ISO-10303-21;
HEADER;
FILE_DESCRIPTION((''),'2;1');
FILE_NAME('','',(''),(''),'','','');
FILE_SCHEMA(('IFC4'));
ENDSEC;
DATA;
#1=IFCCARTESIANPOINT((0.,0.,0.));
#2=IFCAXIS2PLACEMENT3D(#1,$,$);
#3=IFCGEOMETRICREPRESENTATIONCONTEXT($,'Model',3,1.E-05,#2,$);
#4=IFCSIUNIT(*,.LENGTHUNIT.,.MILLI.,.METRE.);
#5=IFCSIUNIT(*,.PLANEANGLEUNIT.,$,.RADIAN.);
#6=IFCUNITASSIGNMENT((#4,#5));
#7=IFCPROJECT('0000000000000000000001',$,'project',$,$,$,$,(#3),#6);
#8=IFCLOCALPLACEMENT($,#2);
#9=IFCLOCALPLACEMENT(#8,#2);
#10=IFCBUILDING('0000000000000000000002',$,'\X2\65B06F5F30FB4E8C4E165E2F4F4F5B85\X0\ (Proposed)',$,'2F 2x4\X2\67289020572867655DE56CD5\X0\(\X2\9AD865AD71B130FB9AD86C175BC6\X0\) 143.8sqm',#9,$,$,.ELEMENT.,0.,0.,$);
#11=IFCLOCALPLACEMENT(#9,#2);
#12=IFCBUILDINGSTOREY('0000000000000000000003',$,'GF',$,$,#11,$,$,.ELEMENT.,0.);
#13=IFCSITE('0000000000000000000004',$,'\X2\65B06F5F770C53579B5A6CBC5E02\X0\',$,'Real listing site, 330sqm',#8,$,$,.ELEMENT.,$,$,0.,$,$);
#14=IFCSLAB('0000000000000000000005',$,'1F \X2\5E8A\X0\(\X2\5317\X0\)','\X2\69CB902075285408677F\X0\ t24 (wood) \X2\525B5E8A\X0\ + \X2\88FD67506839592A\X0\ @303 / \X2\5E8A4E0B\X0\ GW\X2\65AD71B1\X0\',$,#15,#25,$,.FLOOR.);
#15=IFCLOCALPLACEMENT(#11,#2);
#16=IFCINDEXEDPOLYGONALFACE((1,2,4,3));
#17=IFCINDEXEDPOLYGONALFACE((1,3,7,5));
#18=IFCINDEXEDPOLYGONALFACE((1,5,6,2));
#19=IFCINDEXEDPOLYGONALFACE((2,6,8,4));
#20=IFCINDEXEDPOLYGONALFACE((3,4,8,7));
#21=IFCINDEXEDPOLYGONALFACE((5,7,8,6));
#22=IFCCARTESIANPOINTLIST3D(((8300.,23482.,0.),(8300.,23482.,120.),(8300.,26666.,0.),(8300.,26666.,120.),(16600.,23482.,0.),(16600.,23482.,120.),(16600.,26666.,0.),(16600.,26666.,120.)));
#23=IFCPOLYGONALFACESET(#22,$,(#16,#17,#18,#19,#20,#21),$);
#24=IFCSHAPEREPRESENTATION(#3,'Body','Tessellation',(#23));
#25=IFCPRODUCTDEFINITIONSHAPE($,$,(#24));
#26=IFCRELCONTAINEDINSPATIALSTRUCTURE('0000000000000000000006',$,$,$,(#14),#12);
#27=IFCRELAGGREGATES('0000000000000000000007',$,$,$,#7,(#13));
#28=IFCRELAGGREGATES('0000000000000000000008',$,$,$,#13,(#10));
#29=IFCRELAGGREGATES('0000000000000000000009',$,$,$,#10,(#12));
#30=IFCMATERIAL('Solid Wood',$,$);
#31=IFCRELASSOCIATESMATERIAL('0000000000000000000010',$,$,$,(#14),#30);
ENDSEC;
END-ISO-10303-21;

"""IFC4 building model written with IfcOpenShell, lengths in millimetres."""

from ifc_helpers import new_model, si_unit, frame, frame_2d, origin, place, context, project, spatial, rectangle, extrude, material, element, save


model = new_model("IFC4")

# Units and contexts
model_context = context("Model", 3, precision=1e-05, world=origin())
ifc_project = project(units=[si_unit("LENGTHUNIT", "METRE", prefix="MILLI"), si_unit("PLANEANGLEUNIT", "RADIAN")], contexts=[model_context])

# Site, building, storey
site_placement = place(None, origin())
site = spatial("IfcSite", under=ifc_project, at=site_placement, Name="新潟県南魚沼市", ObjectType="Real listing site, 330sqm", CompositionType="ELEMENT", RefElevation=0.0)
building_placement = place(site_placement, origin())
building = spatial("IfcBuilding", under=site, at=building_placement, Name="新潟・二世帯住宅 (Proposed)", ObjectType="2F 2x4木造在来工法(高断熱・高気密) 143.8sqm", CompositionType="ELEMENT", ElevationOfRefHeight=0.0, ElevationOfTerrain=0.0)
storey_placement = place(building_placement, origin())
storey = spatial("IfcBuildingStorey", under=building, at=storey_placement, Name="GF", CompositionType="ELEMENT", Elevation=0.0)

# Shared definitions
ifc_material_1 = material(Name="Solid Wood")

# Slab
slab_1_placement = place(storey_placement, frame((4150.0, 11741.0, 0.0)))
element("IfcSlab", 1, at=slab_1_placement, inside=storey, material=ifc_material_1, Name="1F 床(北)", Description="構造用合板 t24 (wood) 剛床 + 製材根太 @303 / 床下 GW断熱", PredefinedType="FLOOR", context=model_context, shape_type="SweptSolid", body=[
    extrude(rectangle(XDim=8300.0, YDim=3184.0, at=frame_2d((4150.0, 1592.0))), frame((4150.0, 11741.0, 0.0)), (0.0, 0.0, 1.0), 120.0),
])

save(model, "model.ifc")
